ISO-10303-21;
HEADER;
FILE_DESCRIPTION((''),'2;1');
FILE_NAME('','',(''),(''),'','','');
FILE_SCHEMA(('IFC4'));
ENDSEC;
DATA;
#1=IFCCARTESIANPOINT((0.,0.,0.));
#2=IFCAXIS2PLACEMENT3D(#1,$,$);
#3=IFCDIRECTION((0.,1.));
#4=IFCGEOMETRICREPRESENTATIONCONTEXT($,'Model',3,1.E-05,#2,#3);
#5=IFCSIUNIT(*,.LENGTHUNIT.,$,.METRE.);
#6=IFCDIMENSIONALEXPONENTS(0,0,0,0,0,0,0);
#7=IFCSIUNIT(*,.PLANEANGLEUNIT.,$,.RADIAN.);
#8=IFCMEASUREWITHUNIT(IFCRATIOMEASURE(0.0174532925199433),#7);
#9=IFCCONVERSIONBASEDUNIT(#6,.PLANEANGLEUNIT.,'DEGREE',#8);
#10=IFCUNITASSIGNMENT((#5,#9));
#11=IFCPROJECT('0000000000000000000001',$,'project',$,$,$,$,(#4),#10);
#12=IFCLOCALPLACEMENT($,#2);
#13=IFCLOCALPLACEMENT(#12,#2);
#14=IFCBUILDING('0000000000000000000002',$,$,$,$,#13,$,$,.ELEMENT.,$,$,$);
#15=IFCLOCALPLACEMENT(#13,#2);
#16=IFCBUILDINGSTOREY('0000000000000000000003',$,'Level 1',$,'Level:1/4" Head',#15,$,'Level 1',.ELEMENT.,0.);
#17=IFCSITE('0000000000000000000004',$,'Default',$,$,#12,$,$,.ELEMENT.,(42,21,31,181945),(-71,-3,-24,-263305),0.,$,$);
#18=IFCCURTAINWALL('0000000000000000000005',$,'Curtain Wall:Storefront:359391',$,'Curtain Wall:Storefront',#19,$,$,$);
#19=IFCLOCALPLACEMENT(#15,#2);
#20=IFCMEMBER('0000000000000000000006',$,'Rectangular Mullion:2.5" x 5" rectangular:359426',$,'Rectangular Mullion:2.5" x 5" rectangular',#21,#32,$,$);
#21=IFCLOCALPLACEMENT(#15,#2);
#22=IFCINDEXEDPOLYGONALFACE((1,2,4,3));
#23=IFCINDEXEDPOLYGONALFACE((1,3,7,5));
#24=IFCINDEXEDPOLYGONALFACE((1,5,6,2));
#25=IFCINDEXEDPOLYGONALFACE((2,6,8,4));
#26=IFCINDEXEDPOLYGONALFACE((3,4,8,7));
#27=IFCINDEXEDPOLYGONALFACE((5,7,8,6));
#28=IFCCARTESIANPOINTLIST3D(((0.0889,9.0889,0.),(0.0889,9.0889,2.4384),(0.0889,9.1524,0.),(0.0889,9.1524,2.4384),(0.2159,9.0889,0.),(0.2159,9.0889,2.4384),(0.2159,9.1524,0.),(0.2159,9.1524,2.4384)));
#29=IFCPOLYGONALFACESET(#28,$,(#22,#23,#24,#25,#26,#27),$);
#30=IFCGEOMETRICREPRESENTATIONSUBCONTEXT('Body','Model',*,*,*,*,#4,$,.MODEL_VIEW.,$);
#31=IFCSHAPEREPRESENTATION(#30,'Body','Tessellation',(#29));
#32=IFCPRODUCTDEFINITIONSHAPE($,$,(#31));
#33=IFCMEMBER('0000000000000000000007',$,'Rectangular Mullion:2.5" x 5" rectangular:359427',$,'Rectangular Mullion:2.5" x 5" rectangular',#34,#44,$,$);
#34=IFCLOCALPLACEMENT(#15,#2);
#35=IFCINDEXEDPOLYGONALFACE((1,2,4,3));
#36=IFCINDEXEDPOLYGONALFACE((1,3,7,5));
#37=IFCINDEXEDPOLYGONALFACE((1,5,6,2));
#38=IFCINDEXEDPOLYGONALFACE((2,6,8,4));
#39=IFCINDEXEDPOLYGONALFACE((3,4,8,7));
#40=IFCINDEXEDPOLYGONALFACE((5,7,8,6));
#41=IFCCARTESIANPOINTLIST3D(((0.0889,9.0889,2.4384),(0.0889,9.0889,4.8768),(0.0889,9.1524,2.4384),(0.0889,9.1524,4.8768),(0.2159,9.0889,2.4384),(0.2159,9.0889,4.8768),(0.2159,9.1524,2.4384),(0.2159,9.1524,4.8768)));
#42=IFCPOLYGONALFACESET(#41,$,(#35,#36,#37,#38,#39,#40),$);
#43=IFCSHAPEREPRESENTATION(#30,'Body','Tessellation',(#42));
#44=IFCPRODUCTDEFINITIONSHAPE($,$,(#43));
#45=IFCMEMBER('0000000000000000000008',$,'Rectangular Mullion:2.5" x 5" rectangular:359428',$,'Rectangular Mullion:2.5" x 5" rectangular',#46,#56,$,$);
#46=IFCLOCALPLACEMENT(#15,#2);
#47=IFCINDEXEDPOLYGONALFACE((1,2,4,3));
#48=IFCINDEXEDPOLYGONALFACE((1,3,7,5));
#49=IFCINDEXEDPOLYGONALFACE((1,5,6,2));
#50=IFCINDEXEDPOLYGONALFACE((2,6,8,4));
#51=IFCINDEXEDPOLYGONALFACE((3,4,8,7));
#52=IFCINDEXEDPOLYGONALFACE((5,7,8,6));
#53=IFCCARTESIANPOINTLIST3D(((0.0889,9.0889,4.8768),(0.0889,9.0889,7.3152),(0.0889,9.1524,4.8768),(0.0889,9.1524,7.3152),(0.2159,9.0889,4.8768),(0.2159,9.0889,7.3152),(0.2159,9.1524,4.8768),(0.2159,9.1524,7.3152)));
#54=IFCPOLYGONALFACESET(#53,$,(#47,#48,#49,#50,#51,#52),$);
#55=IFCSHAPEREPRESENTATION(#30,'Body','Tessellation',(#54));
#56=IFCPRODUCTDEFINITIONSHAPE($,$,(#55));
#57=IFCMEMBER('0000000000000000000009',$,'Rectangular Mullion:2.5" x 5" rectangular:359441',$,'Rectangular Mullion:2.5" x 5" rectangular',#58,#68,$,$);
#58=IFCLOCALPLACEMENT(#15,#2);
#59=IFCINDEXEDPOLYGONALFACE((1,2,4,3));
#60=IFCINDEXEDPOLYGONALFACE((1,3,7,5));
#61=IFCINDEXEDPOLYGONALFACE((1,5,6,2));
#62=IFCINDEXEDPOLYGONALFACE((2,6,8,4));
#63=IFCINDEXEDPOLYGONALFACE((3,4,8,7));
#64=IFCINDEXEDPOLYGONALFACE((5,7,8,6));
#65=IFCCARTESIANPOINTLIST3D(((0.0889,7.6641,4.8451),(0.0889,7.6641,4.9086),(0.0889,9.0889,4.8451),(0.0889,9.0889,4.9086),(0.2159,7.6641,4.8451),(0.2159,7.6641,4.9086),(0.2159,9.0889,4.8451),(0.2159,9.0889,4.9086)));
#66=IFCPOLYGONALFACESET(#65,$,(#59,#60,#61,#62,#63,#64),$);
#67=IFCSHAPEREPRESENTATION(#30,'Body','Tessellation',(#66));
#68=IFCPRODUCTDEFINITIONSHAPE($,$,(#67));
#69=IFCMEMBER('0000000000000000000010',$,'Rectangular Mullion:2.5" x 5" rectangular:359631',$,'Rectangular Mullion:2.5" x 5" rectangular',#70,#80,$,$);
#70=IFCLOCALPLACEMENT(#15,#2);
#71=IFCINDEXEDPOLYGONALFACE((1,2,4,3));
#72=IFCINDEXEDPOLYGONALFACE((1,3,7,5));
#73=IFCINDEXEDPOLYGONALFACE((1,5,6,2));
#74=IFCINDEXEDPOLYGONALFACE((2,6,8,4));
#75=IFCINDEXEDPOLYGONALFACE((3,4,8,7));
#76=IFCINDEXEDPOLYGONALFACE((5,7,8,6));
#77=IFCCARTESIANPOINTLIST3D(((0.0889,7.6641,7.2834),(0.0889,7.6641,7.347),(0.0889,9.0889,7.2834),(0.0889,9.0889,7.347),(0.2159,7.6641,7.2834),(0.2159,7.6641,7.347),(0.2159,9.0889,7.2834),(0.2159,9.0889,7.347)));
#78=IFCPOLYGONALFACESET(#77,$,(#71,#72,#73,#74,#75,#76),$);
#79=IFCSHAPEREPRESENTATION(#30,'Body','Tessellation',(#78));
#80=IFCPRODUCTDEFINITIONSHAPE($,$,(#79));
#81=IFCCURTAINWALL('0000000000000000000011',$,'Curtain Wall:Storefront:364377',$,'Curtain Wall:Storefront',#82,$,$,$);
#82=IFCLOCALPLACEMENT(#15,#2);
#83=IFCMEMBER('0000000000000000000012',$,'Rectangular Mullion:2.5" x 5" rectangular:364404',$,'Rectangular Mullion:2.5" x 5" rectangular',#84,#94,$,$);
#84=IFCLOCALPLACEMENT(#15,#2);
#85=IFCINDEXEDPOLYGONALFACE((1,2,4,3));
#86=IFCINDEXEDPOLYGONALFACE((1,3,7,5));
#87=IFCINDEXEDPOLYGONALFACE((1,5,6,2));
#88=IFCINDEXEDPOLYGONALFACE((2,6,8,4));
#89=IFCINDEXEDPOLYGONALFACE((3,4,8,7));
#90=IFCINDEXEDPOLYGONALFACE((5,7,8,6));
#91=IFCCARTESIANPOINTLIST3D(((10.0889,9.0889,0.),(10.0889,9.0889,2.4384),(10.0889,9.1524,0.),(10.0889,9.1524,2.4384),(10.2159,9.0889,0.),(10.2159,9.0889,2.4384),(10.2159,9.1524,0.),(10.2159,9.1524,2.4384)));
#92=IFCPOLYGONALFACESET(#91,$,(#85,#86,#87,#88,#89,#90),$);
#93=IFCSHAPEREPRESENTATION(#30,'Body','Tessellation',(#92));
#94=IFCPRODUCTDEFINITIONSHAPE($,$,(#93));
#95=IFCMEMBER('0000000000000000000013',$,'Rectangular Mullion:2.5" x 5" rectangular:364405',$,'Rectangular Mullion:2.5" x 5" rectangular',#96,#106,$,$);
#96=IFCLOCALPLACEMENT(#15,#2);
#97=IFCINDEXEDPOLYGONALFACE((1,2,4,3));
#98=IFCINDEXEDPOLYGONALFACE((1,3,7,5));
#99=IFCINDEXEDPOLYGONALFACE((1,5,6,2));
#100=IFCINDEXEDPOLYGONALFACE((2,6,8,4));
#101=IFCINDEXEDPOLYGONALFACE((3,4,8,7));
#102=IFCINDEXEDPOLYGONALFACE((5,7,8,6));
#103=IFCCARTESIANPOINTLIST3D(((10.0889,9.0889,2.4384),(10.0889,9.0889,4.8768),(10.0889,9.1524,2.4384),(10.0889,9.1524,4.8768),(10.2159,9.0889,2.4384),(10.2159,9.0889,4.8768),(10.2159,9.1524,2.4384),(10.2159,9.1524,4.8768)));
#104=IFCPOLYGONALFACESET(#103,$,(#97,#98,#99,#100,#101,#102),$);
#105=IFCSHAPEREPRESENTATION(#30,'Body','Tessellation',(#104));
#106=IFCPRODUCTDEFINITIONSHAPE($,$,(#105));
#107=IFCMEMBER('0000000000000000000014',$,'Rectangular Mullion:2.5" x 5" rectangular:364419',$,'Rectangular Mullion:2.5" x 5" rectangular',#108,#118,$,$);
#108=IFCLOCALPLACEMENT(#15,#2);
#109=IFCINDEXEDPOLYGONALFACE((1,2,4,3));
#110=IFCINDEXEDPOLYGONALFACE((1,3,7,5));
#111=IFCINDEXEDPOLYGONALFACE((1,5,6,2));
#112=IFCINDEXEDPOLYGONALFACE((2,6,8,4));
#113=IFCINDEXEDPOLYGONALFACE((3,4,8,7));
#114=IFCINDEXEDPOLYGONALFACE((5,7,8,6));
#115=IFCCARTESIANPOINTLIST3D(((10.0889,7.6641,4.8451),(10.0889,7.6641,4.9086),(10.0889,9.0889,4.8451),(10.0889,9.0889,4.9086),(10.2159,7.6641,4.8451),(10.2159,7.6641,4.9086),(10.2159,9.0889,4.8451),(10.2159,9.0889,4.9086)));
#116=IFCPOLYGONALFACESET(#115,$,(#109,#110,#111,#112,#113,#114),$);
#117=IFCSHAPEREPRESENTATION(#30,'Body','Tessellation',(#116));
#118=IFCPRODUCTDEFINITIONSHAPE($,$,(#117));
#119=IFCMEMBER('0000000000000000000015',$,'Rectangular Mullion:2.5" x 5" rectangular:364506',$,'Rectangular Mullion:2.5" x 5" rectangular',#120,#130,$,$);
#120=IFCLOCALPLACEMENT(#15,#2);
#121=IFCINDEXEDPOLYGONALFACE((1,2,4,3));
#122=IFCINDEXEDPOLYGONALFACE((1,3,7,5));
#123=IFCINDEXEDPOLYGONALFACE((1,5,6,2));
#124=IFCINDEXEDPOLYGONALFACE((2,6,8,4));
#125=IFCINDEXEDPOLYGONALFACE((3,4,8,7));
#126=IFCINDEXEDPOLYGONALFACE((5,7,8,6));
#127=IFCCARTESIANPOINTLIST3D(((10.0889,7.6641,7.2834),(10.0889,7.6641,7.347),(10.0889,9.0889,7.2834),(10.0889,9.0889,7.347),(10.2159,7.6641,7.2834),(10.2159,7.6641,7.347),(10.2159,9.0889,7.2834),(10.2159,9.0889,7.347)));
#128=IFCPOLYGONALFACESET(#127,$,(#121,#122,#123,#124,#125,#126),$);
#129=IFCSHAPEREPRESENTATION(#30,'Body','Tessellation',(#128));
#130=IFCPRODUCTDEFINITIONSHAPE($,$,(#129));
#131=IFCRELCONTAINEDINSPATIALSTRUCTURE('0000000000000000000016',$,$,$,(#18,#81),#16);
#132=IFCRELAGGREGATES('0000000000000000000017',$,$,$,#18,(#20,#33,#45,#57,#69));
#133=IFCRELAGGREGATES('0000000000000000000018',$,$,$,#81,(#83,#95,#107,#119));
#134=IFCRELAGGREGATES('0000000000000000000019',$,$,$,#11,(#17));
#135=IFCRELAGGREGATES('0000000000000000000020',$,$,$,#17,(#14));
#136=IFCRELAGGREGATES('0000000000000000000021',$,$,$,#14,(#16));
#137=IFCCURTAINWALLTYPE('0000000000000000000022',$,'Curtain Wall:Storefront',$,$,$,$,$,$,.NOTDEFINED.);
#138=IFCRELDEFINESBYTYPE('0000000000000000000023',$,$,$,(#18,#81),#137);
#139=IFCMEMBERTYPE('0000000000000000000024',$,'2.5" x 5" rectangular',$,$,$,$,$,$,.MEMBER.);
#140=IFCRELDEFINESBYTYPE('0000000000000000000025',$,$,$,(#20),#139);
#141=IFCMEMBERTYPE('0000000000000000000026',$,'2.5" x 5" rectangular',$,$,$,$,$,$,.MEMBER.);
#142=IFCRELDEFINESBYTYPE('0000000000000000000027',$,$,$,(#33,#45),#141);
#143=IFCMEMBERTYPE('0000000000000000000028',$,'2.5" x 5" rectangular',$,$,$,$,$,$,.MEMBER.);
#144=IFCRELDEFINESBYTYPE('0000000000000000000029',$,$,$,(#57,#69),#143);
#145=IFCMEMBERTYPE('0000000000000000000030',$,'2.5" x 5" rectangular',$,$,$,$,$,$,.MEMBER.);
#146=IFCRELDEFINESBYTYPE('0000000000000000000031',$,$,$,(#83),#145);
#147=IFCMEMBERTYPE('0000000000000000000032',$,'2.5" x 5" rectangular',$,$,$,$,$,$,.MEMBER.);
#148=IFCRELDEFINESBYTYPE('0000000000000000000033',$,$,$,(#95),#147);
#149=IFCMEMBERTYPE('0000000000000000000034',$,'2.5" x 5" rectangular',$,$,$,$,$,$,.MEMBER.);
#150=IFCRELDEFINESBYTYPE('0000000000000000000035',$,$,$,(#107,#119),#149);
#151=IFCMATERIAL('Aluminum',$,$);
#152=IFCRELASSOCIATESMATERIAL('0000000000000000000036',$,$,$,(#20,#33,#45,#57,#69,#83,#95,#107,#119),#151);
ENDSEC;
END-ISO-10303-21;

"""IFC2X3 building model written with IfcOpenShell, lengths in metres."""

from ifc_helpers import new_model, entity, si_unit, converted_unit, direction, frame, origin, origin_2d_with_axis, place, context, subcontext, project, spatial, rectangle, extrude, source, transform, mapped, material, type_object, type_shapes, element, aggregate, save


model = new_model("IFC2X3")

# Units and contexts
model_context = context("Model", 3, precision=1e-05, world=origin(), true_north=direction((0.0, 1.0)))
body_context = subcontext(model_context, "Body", "Model", "MODEL_VIEW")
ifc_project = project(units=[si_unit("LENGTHUNIT", "METRE"), converted_unit("PLANEANGLEUNIT", "DEGREE", entity("IfcRatioMeasure", 0.0174532925199433), si_unit("PLANEANGLEUNIT", "RADIAN"), dimensions=[0, 0, 0, 0, 0, 0, 0])], contexts=[model_context])

# Site, building, storey
site_placement = place(None, origin())
site = spatial("IfcSite", under=ifc_project, at=site_placement, Name="Default", CompositionType="ELEMENT", RefLatitude=(42, 21, 31, 181945), RefLongitude=(-71, -3, -24, -263305), RefElevation=0.0)
building_placement = place(site_placement, origin())
building = spatial("IfcBuilding", under=site, at=building_placement, CompositionType="ELEMENT")
storey_placement = place(building_placement, origin())
storey = spatial("IfcBuildingStorey", under=building, at=storey_placement, Name="Level 1", ObjectType="Level:1/4\" Head", LongName="Level 1", CompositionType="ELEMENT", Elevation=0.0)

# Curtain walls, members
curtain_wall_type = type_object("IfcCurtainWallType", Name="Curtain Wall:Storefront", PredefinedType="NOTDEFINED")
curtain_wall_1_placement = place(storey_placement, origin())
curtain_wall_1 = element("IfcCurtainWall", 1, at=curtain_wall_1_placement, inside=storey, type_object=curtain_wall_type, Name="Curtain Wall:Storefront:359391", ObjectType="Curtain Wall:Storefront")
ifc_material = material(Name="Aluminum")
member_type_1 = type_object("IfcMemberType", Name="2.5\" x 5\" rectangular", PredefinedType="MEMBER")
shared_shape_1 = source(origin(), body_context, "Body", "SweptSolid", [
    extrude(rectangle(XDim=0.127, YDim=0.0635, at=origin_2d_with_axis()), frame((-0.0318, 0.0, -2.4384), z_axis=(0.0, 0.0, 1.0), x_axis=(0.0, -1.0, 0.0)), (0.0, 0.0, 1.0), 2.4384),
])
type_shapes(member_type_1, [shared_shape_1])
member_1_placement = place(storey_placement, frame((0.1524, 9.1524, 0.0), z_axis=(0.0, 0.0, -1.0), x_axis=(0.0, 1.0, 0.0)))
member_1 = element("IfcMember", 2, at=member_1_placement, type_object=member_type_1, material=ifc_material, Name="Rectangular Mullion:2.5\" x 5\" rectangular:359426", ObjectType="Rectangular Mullion:2.5\" x 5\" rectangular", context=body_context, shape_type="MappedRepresentation", body=[
    mapped(shared_shape_1, transform((0.0, 0.0, 0.0), scale=1.0)),
])
member_type_2 = type_object("IfcMemberType", Name="2.5\" x 5\" rectangular", PredefinedType="MEMBER")
shared_shape_2 = source(origin(), body_context, "Body", "SweptSolid", [
    extrude(rectangle(XDim=0.127, YDim=0.0635, at=origin_2d_with_axis()), frame((-0.0318, 0.0, -2.4384), z_axis=(0.0, 0.0, 1.0), x_axis=(0.0, -1.0, 0.0)), (0.0, 0.0, 1.0), 2.4384),
])
type_shapes(member_type_2, [shared_shape_2])
member_2_placement = place(storey_placement, frame((0.1524, 9.1524, 2.4384), z_axis=(0.0, 0.0, -1.0), x_axis=(0.0, 1.0, 0.0)))
member_2 = element("IfcMember", 3, at=member_2_placement, type_object=member_type_2, material=ifc_material, Name="Rectangular Mullion:2.5\" x 5\" rectangular:359427", ObjectType="Rectangular Mullion:2.5\" x 5\" rectangular", context=body_context, shape_type="MappedRepresentation", body=[
    mapped(shared_shape_2, transform((0.0, 0.0, 0.0), scale=1.0)),
])
member_3_placement = place(storey_placement, frame((0.1524, 9.1524, 4.8768), z_axis=(0.0, 0.0, -1.0), x_axis=(0.0, 1.0, 0.0)))
member_3 = element("IfcMember", 4, at=member_3_placement, type_object=member_type_2, material=ifc_material, Name="Rectangular Mullion:2.5\" x 5\" rectangular:359428", ObjectType="Rectangular Mullion:2.5\" x 5\" rectangular", context=body_context, shape_type="MappedRepresentation", body=[
    mapped(shared_shape_2, transform((0.0, 0.0, 0.0), scale=1.0)),
])
member_type_3 = type_object("IfcMemberType", Name="2.5\" x 5\" rectangular", PredefinedType="MEMBER")
shared_shape_3 = source(origin(), body_context, "Body", "SweptSolid", [
    extrude(rectangle(XDim=0.127, YDim=0.0635, at=origin_2d_with_axis()), frame((0.0, 0.0, -1.4248), z_axis=(0.0, 0.0, 1.0), x_axis=(0.0, -1.0, 0.0)), (0.0, 0.0, 1.0), 1.4248),
])
type_shapes(member_type_3, [shared_shape_3])
member_4_placement = place(storey_placement, frame((0.1524, 9.0889, 4.8768), z_axis=(0.0, 1.0, 0.0), x_axis=(0.0, 0.0, 1.0)))
member_4 = element("IfcMember", 5, at=member_4_placement, type_object=member_type_3, material=ifc_material, Name="Rectangular Mullion:2.5\" x 5\" rectangular:359441", ObjectType="Rectangular Mullion:2.5\" x 5\" rectangular", context=body_context, shape_type="MappedRepresentation", body=[
    mapped(shared_shape_3, transform((0.0, 0.0, 0.0), scale=1.0)),
])
member_5_placement = place(storey_placement, frame((0.1524, 9.0889, 7.3152), z_axis=(0.0, 1.0, 0.0), x_axis=(0.0, 0.0, 1.0)))
member_5 = element("IfcMember", 6, at=member_5_placement, type_object=member_type_3, material=ifc_material, Name="Rectangular Mullion:2.5\" x 5\" rectangular:359631", ObjectType="Rectangular Mullion:2.5\" x 5\" rectangular", context=body_context, shape_type="MappedRepresentation", body=[
    mapped(shared_shape_3, transform((0.0, 0.0, 0.0), scale=1.0)),
])
aggregate(curtain_wall_1, [member_1, member_2, member_3, member_4, member_5])
curtain_wall_2_placement = place(storey_placement, origin())
curtain_wall_2 = element("IfcCurtainWall", 7, at=curtain_wall_2_placement, inside=storey, type_object=curtain_wall_type, Name="Curtain Wall:Storefront:364377", ObjectType="Curtain Wall:Storefront")
member_type_4 = type_object("IfcMemberType", Name="2.5\" x 5\" rectangular", PredefinedType="MEMBER")
shared_shape_4 = source(origin(), body_context, "Body", "SweptSolid", [
    extrude(rectangle(XDim=0.127, YDim=0.0635, at=origin_2d_with_axis()), frame((-0.0318, 0.0, -2.4384), z_axis=(0.0, 0.0, 1.0), x_axis=(0.0, -1.0, 0.0)), (0.0, 0.0, 1.0), 2.4384),
])
type_shapes(member_type_4, [shared_shape_4])
member_6_placement = place(storey_placement, frame((10.1524, 9.1524, 0.0), z_axis=(0.0, 0.0, -1.0), x_axis=(0.0, 1.0, 0.0)))
member_6 = element("IfcMember", 8, at=member_6_placement, type_object=member_type_4, material=ifc_material, Name="Rectangular Mullion:2.5\" x 5\" rectangular:364404", ObjectType="Rectangular Mullion:2.5\" x 5\" rectangular", context=body_context, shape_type="MappedRepresentation", body=[
    mapped(shared_shape_4, transform((0.0, 0.0, 0.0), scale=1.0)),
])
member_type_5 = type_object("IfcMemberType", Name="2.5\" x 5\" rectangular", PredefinedType="MEMBER")
shared_shape_5 = source(origin(), body_context, "Body", "SweptSolid", [
    extrude(rectangle(XDim=0.127, YDim=0.0635, at=origin_2d_with_axis()), frame((-0.0318, 0.0, -2.4384), z_axis=(0.0, 0.0, 1.0), x_axis=(0.0, -1.0, 0.0)), (0.0, 0.0, 1.0), 2.4384),
])
type_shapes(member_type_5, [shared_shape_5])
member_7_placement = place(storey_placement, frame((10.1524, 9.1524, 2.4384), z_axis=(0.0, 0.0, -1.0), x_axis=(0.0, 1.0, 0.0)))
member_7 = element("IfcMember", 9, at=member_7_placement, type_object=member_type_5, material=ifc_material, Name="Rectangular Mullion:2.5\" x 5\" rectangular:364405", ObjectType="Rectangular Mullion:2.5\" x 5\" rectangular", context=body_context, shape_type="MappedRepresentation", body=[
    mapped(shared_shape_5, transform((0.0, 0.0, 0.0), scale=1.0)),
])
member_type_6 = type_object("IfcMemberType", Name="2.5\" x 5\" rectangular", PredefinedType="MEMBER")
shared_shape_6 = source(origin(), body_context, "Body", "SweptSolid", [
    extrude(rectangle(XDim=0.127, YDim=0.0635, at=origin_2d_with_axis()), frame((0.0, 0.0, -1.4248), z_axis=(0.0, 0.0, 1.0), x_axis=(0.0, -1.0, 0.0)), (0.0, 0.0, 1.0), 1.4248),
])
type_shapes(member_type_6, [shared_shape_6])
member_8_placement = place(storey_placement, frame((10.1524, 9.0889, 4.8768), z_axis=(0.0, 1.0, 0.0), x_axis=(0.0, 0.0, 1.0)))
member_8 = element("IfcMember", 10, at=member_8_placement, type_object=member_type_6, material=ifc_material, Name="Rectangular Mullion:2.5\" x 5\" rectangular:364419", ObjectType="Rectangular Mullion:2.5\" x 5\" rectangular", context=body_context, shape_type="MappedRepresentation", body=[
    mapped(shared_shape_6, transform((0.0, 0.0, 0.0), scale=1.0)),
])
member_9_placement = place(storey_placement, frame((10.1524, 9.0889, 7.3152), z_axis=(0.0, 1.0, 0.0), x_axis=(0.0, 0.0, 1.0)))
member_9 = element("IfcMember", 11, at=member_9_placement, type_object=member_type_6, material=ifc_material, Name="Rectangular Mullion:2.5\" x 5\" rectangular:364506", ObjectType="Rectangular Mullion:2.5\" x 5\" rectangular", context=body_context, shape_type="MappedRepresentation", body=[
    mapped(shared_shape_6, transform((0.0, 0.0, 0.0), scale=1.0)),
])
aggregate(curtain_wall_2, [member_6, member_7, member_8, member_9])

save(model, "model.ifc")
